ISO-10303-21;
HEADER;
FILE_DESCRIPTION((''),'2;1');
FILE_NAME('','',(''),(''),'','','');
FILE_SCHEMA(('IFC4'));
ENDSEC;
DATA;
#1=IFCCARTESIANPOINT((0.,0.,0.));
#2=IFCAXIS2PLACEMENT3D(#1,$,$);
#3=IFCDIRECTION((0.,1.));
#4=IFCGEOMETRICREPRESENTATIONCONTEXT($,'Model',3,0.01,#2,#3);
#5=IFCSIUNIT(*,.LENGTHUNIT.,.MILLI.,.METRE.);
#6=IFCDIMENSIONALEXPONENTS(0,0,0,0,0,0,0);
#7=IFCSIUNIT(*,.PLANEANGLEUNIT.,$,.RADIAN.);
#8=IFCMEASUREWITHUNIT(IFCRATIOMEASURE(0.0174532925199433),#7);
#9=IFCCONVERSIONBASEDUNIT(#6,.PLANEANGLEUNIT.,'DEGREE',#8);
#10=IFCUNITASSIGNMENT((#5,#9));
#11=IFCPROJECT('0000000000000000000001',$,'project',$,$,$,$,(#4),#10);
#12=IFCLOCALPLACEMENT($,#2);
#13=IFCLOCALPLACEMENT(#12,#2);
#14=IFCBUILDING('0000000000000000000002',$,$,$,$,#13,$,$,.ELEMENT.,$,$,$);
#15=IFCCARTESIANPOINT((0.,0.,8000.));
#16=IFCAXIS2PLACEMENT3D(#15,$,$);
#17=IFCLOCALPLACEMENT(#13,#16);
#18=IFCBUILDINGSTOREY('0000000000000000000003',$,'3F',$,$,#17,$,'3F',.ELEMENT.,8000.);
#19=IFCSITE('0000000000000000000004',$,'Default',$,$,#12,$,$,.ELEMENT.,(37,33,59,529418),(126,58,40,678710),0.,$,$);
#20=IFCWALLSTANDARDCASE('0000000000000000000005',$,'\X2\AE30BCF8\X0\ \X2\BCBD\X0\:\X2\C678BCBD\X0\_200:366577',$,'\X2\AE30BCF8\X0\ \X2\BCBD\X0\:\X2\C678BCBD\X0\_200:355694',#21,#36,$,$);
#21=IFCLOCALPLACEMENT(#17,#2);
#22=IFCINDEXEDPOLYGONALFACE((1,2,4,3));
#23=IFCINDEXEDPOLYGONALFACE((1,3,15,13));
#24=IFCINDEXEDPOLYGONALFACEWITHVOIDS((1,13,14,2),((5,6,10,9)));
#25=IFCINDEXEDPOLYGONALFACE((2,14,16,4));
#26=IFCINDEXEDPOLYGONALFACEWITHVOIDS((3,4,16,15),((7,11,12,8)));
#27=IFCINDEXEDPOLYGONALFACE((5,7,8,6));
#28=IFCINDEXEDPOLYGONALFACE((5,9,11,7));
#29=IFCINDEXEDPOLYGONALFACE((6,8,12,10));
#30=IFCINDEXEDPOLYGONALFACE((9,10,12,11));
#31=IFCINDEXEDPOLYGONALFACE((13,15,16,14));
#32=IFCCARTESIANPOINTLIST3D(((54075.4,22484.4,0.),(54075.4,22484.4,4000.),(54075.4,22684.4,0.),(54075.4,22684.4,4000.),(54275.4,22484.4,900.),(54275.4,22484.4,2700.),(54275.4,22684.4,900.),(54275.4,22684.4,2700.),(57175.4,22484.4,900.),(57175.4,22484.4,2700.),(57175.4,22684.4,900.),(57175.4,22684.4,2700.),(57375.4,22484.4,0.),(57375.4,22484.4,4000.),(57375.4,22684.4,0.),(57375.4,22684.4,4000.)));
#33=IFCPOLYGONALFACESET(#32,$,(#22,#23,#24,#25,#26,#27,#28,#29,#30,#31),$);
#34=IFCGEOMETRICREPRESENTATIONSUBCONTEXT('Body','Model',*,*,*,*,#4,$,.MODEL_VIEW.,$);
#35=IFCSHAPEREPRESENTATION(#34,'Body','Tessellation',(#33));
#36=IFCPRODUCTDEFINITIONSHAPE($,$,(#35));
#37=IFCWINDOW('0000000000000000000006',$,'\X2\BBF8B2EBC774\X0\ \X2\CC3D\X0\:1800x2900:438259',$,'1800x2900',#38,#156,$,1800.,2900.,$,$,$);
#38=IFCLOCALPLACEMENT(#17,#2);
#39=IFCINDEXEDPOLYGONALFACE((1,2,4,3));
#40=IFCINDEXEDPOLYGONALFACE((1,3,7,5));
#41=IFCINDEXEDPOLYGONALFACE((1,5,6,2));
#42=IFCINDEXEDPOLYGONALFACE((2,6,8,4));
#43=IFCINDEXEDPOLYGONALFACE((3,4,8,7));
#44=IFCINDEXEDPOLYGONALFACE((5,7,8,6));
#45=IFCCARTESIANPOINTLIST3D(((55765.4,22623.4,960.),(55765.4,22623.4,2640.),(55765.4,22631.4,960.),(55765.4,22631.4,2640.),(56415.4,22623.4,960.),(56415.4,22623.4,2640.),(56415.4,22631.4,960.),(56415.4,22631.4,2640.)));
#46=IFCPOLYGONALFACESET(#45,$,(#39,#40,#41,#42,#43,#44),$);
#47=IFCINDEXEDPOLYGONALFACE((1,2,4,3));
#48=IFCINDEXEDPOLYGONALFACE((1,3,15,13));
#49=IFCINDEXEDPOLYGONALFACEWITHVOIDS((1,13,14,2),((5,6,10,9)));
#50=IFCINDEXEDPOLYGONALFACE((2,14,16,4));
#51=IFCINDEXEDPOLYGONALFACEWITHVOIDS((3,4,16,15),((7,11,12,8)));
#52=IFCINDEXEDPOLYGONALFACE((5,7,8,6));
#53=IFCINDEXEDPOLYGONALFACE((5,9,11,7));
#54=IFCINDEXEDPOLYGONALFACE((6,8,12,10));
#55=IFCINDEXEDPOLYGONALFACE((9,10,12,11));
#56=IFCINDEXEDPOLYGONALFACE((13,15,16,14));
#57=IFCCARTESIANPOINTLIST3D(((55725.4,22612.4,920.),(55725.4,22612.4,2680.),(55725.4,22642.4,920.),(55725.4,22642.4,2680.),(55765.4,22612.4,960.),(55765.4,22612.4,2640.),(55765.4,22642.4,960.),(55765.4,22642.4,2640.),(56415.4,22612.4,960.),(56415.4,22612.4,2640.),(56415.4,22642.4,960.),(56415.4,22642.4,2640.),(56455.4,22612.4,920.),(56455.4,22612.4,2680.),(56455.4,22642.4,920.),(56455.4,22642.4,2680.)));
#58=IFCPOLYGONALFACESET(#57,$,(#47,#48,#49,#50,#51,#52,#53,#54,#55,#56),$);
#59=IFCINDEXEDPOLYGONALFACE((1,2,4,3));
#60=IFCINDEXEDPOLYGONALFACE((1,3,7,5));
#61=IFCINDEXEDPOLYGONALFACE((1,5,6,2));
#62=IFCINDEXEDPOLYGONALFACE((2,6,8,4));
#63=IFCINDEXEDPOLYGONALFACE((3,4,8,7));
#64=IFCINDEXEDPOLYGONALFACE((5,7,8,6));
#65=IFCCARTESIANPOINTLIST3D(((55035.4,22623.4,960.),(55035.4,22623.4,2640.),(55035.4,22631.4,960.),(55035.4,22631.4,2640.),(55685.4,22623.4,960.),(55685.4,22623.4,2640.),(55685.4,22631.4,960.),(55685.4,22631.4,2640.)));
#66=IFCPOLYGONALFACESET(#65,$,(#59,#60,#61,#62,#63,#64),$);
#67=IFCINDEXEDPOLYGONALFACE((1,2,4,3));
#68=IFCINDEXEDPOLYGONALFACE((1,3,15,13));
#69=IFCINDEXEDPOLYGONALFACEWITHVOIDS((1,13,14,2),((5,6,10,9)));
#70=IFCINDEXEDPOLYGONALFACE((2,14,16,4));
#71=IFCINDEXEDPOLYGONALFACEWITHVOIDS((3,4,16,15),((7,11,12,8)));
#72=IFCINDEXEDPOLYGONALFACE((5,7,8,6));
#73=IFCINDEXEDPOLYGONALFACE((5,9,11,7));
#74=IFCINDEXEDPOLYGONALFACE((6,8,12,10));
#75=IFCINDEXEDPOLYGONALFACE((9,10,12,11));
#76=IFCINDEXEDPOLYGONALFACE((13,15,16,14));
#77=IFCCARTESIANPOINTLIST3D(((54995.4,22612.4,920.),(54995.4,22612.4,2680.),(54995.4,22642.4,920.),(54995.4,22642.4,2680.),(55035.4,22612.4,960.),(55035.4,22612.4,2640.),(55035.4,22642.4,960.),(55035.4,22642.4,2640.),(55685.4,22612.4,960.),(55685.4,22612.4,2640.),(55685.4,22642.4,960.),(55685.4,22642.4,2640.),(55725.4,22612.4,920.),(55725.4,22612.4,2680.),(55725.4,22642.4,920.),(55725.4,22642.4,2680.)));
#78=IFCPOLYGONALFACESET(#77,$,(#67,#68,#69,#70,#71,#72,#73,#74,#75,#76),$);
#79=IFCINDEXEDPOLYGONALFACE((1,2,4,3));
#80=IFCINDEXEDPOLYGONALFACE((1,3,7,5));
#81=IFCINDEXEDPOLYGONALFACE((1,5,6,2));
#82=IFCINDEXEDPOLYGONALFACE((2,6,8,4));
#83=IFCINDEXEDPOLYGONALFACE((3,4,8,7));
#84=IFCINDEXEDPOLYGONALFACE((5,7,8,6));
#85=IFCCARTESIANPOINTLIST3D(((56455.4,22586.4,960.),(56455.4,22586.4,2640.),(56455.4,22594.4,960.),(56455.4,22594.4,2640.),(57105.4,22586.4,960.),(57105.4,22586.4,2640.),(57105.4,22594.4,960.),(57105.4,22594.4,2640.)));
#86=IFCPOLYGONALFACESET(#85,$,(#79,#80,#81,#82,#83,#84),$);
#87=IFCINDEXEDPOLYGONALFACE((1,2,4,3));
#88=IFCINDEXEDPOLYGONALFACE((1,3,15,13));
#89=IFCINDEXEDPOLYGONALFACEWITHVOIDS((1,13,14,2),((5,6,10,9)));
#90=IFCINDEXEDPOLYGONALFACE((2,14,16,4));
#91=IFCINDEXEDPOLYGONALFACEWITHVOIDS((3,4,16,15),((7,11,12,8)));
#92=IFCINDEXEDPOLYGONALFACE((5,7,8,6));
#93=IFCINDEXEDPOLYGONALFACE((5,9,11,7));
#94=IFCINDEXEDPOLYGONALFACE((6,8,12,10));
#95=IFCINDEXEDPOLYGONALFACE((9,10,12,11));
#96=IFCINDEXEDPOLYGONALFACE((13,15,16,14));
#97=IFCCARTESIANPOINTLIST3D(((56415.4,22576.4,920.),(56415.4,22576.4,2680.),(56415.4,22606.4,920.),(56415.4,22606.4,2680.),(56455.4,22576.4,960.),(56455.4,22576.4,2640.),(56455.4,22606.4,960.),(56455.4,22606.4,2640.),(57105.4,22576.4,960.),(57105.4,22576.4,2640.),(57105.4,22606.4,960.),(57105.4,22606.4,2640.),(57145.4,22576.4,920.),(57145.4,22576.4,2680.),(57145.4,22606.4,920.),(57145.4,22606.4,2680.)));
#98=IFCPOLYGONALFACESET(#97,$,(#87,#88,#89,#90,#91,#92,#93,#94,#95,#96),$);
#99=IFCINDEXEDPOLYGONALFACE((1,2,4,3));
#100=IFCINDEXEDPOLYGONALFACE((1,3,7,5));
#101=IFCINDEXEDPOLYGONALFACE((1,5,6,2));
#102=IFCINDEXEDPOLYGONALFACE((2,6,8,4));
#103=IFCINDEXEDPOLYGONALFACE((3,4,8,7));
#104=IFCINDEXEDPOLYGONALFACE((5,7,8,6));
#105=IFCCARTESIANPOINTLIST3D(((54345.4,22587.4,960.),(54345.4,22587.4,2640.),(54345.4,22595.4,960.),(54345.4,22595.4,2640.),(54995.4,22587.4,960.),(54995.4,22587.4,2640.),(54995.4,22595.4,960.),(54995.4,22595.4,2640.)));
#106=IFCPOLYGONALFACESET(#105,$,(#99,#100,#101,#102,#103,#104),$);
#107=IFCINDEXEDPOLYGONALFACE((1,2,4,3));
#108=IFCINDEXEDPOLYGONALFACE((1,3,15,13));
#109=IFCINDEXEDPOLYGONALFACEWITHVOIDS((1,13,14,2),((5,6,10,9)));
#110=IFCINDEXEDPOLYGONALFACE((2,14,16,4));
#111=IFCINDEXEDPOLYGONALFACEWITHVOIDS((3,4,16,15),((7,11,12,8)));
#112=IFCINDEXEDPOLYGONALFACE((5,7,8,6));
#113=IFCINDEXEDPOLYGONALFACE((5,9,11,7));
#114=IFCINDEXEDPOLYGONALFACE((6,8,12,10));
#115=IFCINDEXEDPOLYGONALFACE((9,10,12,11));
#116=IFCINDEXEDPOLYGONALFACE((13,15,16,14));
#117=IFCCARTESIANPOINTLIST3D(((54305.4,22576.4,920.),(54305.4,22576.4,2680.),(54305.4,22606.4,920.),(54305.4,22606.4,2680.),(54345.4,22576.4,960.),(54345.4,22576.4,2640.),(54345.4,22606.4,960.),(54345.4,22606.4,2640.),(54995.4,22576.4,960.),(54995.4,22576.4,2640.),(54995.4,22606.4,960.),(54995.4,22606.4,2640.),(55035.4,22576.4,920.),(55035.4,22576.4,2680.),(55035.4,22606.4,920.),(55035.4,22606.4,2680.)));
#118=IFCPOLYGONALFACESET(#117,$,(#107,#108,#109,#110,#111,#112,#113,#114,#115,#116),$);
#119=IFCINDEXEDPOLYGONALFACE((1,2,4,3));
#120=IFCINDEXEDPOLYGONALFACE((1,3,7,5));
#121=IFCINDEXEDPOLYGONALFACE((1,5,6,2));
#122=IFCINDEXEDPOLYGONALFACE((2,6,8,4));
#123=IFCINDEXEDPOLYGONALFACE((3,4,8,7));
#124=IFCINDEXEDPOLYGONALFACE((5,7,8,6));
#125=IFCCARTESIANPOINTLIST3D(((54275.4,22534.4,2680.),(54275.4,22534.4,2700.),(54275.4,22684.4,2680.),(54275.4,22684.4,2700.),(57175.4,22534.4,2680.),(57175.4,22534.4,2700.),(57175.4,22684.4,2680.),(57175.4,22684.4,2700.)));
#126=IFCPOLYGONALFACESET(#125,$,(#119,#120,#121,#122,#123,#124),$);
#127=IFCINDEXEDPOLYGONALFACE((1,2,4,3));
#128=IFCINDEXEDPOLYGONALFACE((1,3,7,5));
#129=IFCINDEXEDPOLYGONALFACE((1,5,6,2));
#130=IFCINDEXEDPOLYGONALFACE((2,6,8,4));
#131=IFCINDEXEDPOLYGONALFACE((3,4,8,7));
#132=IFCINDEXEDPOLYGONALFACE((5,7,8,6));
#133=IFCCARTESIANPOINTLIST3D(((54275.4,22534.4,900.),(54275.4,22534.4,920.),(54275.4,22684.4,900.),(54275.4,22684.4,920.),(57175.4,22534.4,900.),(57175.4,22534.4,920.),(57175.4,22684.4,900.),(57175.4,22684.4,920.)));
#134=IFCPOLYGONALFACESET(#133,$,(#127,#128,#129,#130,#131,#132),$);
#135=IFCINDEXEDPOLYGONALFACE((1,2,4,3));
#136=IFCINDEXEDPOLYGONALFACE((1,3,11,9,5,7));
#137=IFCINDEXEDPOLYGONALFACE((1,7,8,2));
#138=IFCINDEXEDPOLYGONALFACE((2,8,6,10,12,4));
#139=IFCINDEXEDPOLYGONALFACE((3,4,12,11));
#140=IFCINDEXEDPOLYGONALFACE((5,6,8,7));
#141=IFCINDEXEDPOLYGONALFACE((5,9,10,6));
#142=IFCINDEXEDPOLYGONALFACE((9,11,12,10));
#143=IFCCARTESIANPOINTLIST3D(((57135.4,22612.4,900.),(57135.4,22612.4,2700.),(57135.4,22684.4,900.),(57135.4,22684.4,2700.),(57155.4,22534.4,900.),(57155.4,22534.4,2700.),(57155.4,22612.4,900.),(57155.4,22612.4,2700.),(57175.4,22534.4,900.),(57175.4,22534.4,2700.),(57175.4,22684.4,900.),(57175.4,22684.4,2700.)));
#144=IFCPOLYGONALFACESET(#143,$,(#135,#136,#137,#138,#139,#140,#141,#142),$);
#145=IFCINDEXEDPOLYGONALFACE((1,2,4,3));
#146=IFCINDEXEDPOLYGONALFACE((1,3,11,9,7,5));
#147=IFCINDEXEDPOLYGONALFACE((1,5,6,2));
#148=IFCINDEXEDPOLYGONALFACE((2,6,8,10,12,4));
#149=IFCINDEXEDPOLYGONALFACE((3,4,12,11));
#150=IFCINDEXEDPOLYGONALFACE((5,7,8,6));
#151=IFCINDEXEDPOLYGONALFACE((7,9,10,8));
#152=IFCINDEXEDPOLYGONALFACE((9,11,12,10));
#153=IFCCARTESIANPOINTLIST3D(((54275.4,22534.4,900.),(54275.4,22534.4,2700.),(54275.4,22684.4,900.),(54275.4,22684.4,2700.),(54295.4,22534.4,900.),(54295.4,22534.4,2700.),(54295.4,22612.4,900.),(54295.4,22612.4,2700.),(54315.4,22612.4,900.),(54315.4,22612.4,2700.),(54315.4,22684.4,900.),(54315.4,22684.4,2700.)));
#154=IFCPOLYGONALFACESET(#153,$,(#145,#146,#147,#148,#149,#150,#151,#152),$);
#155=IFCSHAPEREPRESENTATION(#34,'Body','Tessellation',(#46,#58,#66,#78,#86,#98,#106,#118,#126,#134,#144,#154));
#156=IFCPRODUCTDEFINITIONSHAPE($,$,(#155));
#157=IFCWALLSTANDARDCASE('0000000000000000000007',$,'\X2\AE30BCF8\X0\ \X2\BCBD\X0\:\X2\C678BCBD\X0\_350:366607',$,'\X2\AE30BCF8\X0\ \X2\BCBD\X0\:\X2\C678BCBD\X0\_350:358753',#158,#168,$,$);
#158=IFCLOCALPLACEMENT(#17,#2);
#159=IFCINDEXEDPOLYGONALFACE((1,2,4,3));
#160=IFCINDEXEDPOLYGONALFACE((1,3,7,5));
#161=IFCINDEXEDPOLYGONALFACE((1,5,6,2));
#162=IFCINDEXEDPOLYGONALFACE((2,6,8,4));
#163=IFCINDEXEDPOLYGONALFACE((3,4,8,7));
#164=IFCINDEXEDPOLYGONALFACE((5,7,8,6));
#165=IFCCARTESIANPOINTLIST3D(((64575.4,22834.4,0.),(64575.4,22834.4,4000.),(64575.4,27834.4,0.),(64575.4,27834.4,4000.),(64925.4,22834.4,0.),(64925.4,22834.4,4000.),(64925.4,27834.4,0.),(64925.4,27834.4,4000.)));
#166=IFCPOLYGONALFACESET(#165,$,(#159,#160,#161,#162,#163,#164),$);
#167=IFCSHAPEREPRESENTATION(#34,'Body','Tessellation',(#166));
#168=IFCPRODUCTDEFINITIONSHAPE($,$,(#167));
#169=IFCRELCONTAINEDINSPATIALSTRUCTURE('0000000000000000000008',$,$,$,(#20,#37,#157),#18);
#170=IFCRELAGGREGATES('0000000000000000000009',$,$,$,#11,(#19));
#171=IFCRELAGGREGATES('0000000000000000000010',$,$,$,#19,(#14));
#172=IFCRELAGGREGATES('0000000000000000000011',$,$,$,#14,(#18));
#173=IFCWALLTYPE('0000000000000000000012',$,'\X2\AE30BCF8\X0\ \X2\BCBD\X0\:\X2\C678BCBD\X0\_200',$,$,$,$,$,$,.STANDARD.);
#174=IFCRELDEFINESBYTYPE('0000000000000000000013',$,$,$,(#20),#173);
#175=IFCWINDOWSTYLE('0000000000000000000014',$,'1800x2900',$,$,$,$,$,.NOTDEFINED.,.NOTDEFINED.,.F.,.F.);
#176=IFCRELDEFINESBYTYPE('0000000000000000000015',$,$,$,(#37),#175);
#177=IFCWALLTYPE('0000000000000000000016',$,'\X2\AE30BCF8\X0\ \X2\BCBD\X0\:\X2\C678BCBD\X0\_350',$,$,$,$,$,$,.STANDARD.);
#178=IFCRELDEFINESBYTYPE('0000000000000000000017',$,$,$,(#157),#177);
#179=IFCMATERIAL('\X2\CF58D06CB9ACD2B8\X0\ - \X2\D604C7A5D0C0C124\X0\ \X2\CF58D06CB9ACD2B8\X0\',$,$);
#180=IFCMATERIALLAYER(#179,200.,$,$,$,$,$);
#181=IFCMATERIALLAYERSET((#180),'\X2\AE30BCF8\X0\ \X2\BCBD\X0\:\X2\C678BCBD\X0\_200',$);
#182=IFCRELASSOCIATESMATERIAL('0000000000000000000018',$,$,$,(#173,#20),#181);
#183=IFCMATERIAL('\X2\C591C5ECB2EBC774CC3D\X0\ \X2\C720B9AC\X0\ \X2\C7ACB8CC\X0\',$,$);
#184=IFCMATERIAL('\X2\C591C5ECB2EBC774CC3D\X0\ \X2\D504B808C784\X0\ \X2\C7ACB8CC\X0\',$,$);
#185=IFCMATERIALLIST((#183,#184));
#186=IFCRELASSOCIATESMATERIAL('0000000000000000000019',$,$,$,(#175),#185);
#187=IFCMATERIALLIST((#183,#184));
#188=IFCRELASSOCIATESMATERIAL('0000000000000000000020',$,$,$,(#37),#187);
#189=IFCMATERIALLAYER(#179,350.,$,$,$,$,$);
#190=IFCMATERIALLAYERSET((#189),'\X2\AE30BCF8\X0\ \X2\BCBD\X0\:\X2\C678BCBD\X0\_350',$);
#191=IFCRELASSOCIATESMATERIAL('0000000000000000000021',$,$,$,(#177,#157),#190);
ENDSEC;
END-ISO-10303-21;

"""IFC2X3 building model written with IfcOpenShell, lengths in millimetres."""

from ifc_helpers import new_model, entity, si_unit, converted_unit, direction, frame, frame_2d, origin, origin_2d_with_axis, place, context, subcontext, project, spatial, polyline, rectangle, outline, extrude, source, transform, mapped, material, material_list, layer, layer_set, layer_usage, type_object, type_shapes, element, fill, save


model = new_model("IFC2X3")

# Units and contexts
model_context = context("Model", 3, precision=0.01, world=origin(), true_north=direction((0.0, 1.0)))
body_context = subcontext(model_context, "Body", "Model", "MODEL_VIEW")
ifc_project = project(units=[si_unit("LENGTHUNIT", "METRE", prefix="MILLI"), converted_unit("PLANEANGLEUNIT", "DEGREE", entity("IfcRatioMeasure", 0.0174532925199433), si_unit("PLANEANGLEUNIT", "RADIAN"), dimensions=[0, 0, 0, 0, 0, 0, 0])], contexts=[model_context])

# Site, building, storey
site_placement = place(None, origin())
site = spatial("IfcSite", under=ifc_project, at=site_placement, Name="Default", CompositionType="ELEMENT", RefLatitude=(37, 33, 59, 529418), RefLongitude=(126, 58, 40, 678710), RefElevation=0.0)
building_placement = place(site_placement, origin())
building = spatial("IfcBuilding", under=site, at=building_placement, CompositionType="ELEMENT")
storey_placement = place(building_placement, frame((0.0, 0.0, 8000.0)))
storey = spatial("IfcBuildingStorey", under=building, at=storey_placement, Name="3F", LongName="3F", CompositionType="ELEMENT", Elevation=8000.0)

# Wall, opening, window
ifc_material_1 = material(Name="콘크리트 - 현장타설 콘크리트")
ifc_layer_1 = layer(ifc_material_1, 200.0)
ifc_layer_set_1 = layer_set([ifc_layer_1], Name="기본 벽:외벽_200")
wall_type_1 = type_object("IfcWallType", Name="기본 벽:외벽_200", PredefinedType="STANDARD", material=ifc_layer_set_1)
ifc_material_2 = material(Name="양여닫이창 유리 재료")
ifc_material_3 = material(Name="양여닫이창 프레임 재료")
ifc_material_list_1 = material_list([ifc_material_2, ifc_material_3])
window_style = type_object("IfcWindowStyle", Name="1800x2900", ConstructionType="NOTDEFINED", OperationType="NOTDEFINED", ParameterTakesPrecedence=False, Sizeable=False, material=ifc_material_list_1)
shared_shape_1 = source(origin(), body_context, "Body", "SweptSolid", [
    extrude(rectangle(XDim=8.0, YDim=650.0, at=frame_2d((0.0, 0.0), x_axis=(1.0, 0.0))), frame((1815.0, 143.0, 60.0), z_axis=(0.0, 0.0, 1.0), x_axis=(0.0, 1.0, 0.0)), (0.0, 0.0, 1.0), 1680.0),
    extrude(outline(polyline([(-880.0, -365.0), (880.0, -365.0), (880.0, 365.0), (-880.0, 365.0), (-880.0, -365.0)]), holes=[polyline([(840.0, -325.0), (-840.0, -325.0), (-840.0, 325.0), (840.0, 325.0), (840.0, -325.0)])]), frame((1815.0, 128.0, 900.0), z_axis=(0.0, 1.0, 0.0), x_axis=(0.0, 0.0, -1.0)), (0.0, 0.0, 1.0), 30.0),
    extrude(rectangle(XDim=8.0, YDim=650.0, at=frame_2d((0.0, 0.0), x_axis=(1.0, 0.0))), frame((1085.0, 143.0, 60.0), z_axis=(0.0, 0.0, 1.0), x_axis=(0.0, 1.0, 0.0)), (0.0, 0.0, 1.0), 1680.0),
    extrude(outline(polyline([(-880.0, -365.0), (880.0, -365.0), (880.0, 365.0), (-880.0, 365.0), (-880.0, -365.0)]), holes=[polyline([(840.0, -325.0), (-840.0, -325.0), (-840.0, 325.0), (840.0, 325.0), (840.0, -325.0)])]), frame((1085.0, 128.0, 900.0), z_axis=(0.0, 1.0, 0.0), x_axis=(0.0, 0.0, -1.0)), (0.0, 0.0, 1.0), 30.0),
    extrude(rectangle(XDim=8.0, YDim=650.0, at=frame_2d((0.0, 0.0), x_axis=(1.0, 0.0))), frame((2505.0, 106.0, 60.0), z_axis=(0.0, 0.0, 1.0), x_axis=(0.0, 1.0, 0.0)), (0.0, 0.0, 1.0), 1680.0),
    extrude(outline(polyline([(-880.0, -365.0), (880.0, -365.0), (880.0, 365.0), (-880.0, 365.0), (-880.0, -365.0)]), holes=[polyline([(840.0, -325.0), (-840.0, -325.0), (-840.0, 325.0), (840.0, 325.0), (840.0, -325.0)])]), frame((2505.0, 92.0, 900.0), z_axis=(0.0, 1.0, 0.0), x_axis=(0.0, 0.0, -1.0)), (0.0, 0.0, 1.0), 30.0),
    extrude(rectangle(XDim=8.0, YDim=650.0, at=origin_2d_with_axis()), frame((395.0, 107.0, 60.0), z_axis=(0.0, 0.0, 1.0), x_axis=(0.0, 1.0, 0.0)), (0.0, 0.0, 1.0), 1680.0),
    extrude(outline(polyline([(-880.0, -365.0), (880.0, -365.0), (880.0, 365.0), (-880.0, 365.0), (-880.0, -365.0)]), holes=[polyline([(840.0, -325.0), (-840.0, -325.0), (-840.0, 325.0), (840.0, 325.0), (840.0, -325.0)])]), frame((395.0, 92.0, 900.0), z_axis=(0.0, 1.0, 0.0), x_axis=(0.0, 0.0, -1.0)), (0.0, 0.0, 1.0), 30.0),
    extrude(rectangle(XDim=2900.0, YDim=150.0, at=origin_2d_with_axis()), frame((1450.0, 125.0, 1780.0), z_axis=(0.0, 0.0, 1.0), x_axis=(-1.0, 0.0, 0.0)), (0.0, 0.0, 1.0), 20.0),
    extrude(rectangle(XDim=2900.0, YDim=150.0, at=origin_2d_with_axis()), frame((1450.0, 125.0, 0.0), z_axis=(0.0, 0.0, 1.0), x_axis=(-1.0, 0.0, 0.0)), (0.0, 0.0, 1.0), 20.0),
    extrude(outline(polyline([(-74.0, -20.0), (-2.0, -20.0), (-2.0, 0.0), (76.0, 0.0), (76.0, 20.0), (-74.0, 20.0), (-74.0, -20.0)])), frame((2880.0, 126.0, 0.0), z_axis=(0.0, 0.0, 1.0), x_axis=(0.0, -1.0, 0.0)), (0.0, 0.0, 1.0), 1800.0),
    extrude(outline(polyline([(-20.0, -74.0), (20.0, -74.0), (20.0, 76.0), (0.0, 76.0), (0.0, -2.0), (-20.0, -2.0), (-20.0, -74.0)])), frame((20.0, 126.0, 0.0), z_axis=(0.0, 0.0, 1.0), x_axis=(-1.0, 0.0, 0.0)), (0.0, 0.0, 1.0), 1800.0),
])
type_shapes(window_style, [shared_shape_1])
ifc_layer_usage_1 = layer_usage(ifc_layer_set_1, "AXIS2", "NEGATIVE", 100.0)
wall_1_placement = place(storey_placement, frame((57375.4, 22584.4, 0.0), z_axis=(0.0, 0.0, 1.0), x_axis=(-1.0, 0.0, 0.0)))
wall_1 = element("IfcWallStandardCase", 1, at=wall_1_placement, inside=storey, type_object=wall_type_1, material=ifc_layer_usage_1, Name="기본 벽:외벽_200:366577", ObjectType="기본 벽:외벽_200:355694", context=body_context, shape_type="SweptSolid", body=[
    extrude(rectangle(XDim=3300.0, YDim=200.0, at=frame_2d((1650.0, 0.0), x_axis=(-1.0, 0.0))), origin(), (0.0, 0.0, 1.0), 4000.0),
])
opening_1_placement = place(wall_1_placement, frame((3100.0, 100.0, 900.0)))
opening_1 = element("IfcOpeningElement", 2, at=opening_1_placement, cuts=wall_1, ObjectType="Opening", context=body_context, shape_type="SweptSolid", body=[
    extrude(rectangle(XDim=1800.0, YDim=2900.0, at=frame_2d((900.0, 1450.0), x_axis=(1.0, 0.0))), frame((0.0, 0.0, 0.0), z_axis=(0.0, -1.0, 0.0), x_axis=(0.0, 0.0, 1.0)), (0.0, 0.0, 1.0), 200.0),
])
ifc_material_list_2 = material_list([ifc_material_2, ifc_material_3])
window_1_placement = place(opening_1_placement, frame((0.0, 0.0, 0.0), z_axis=(0.0, 0.0, 1.0), x_axis=(-1.0, 0.0, 0.0)))
window_1 = element("IfcWindow", 3, at=window_1_placement, inside=storey, type_object=window_style, material=ifc_material_list_2, Name="미닫이 창:1800x2900:438259", ObjectType="1800x2900", OverallHeight=1800.0, OverallWidth=2900.0, context=body_context, shape_type="MappedRepresentation", body=[
    mapped(shared_shape_1, transform((0.0, 0.0, 0.0), scale=1.0)),
])
fill(opening_1, window_1)

# Wall
ifc_layer_2 = layer(ifc_material_1, 350.0)
ifc_layer_set_2 = layer_set([ifc_layer_2], Name="기본 벽:외벽_350")
ifc_layer_usage_2 = layer_usage(ifc_layer_set_2, "AXIS2", "NEGATIVE", 175.0)
wall_type_2 = type_object("IfcWallType", Name="기본 벽:외벽_350", PredefinedType="STANDARD", material=ifc_layer_set_2)
wall_2_placement = place(storey_placement, frame((64750.4, 27834.4, 0.0), z_axis=(0.0, 0.0, 1.0), x_axis=(0.0, -1.0, 0.0)))
element("IfcWallStandardCase", 4, at=wall_2_placement, inside=storey, type_object=wall_type_2, material=ifc_layer_usage_2, Name="기본 벽:외벽_350:366607", ObjectType="기본 벽:외벽_350:358753", context=body_context, shape_type="SweptSolid", body=[
    extrude(rectangle(XDim=5000.0, YDim=350.0, at=frame_2d((2500.0, 0.0), x_axis=(-1.0, 0.0))), origin(), (0.0, 0.0, 1.0), 4000.0),
])

save(model, "model.ifc")
